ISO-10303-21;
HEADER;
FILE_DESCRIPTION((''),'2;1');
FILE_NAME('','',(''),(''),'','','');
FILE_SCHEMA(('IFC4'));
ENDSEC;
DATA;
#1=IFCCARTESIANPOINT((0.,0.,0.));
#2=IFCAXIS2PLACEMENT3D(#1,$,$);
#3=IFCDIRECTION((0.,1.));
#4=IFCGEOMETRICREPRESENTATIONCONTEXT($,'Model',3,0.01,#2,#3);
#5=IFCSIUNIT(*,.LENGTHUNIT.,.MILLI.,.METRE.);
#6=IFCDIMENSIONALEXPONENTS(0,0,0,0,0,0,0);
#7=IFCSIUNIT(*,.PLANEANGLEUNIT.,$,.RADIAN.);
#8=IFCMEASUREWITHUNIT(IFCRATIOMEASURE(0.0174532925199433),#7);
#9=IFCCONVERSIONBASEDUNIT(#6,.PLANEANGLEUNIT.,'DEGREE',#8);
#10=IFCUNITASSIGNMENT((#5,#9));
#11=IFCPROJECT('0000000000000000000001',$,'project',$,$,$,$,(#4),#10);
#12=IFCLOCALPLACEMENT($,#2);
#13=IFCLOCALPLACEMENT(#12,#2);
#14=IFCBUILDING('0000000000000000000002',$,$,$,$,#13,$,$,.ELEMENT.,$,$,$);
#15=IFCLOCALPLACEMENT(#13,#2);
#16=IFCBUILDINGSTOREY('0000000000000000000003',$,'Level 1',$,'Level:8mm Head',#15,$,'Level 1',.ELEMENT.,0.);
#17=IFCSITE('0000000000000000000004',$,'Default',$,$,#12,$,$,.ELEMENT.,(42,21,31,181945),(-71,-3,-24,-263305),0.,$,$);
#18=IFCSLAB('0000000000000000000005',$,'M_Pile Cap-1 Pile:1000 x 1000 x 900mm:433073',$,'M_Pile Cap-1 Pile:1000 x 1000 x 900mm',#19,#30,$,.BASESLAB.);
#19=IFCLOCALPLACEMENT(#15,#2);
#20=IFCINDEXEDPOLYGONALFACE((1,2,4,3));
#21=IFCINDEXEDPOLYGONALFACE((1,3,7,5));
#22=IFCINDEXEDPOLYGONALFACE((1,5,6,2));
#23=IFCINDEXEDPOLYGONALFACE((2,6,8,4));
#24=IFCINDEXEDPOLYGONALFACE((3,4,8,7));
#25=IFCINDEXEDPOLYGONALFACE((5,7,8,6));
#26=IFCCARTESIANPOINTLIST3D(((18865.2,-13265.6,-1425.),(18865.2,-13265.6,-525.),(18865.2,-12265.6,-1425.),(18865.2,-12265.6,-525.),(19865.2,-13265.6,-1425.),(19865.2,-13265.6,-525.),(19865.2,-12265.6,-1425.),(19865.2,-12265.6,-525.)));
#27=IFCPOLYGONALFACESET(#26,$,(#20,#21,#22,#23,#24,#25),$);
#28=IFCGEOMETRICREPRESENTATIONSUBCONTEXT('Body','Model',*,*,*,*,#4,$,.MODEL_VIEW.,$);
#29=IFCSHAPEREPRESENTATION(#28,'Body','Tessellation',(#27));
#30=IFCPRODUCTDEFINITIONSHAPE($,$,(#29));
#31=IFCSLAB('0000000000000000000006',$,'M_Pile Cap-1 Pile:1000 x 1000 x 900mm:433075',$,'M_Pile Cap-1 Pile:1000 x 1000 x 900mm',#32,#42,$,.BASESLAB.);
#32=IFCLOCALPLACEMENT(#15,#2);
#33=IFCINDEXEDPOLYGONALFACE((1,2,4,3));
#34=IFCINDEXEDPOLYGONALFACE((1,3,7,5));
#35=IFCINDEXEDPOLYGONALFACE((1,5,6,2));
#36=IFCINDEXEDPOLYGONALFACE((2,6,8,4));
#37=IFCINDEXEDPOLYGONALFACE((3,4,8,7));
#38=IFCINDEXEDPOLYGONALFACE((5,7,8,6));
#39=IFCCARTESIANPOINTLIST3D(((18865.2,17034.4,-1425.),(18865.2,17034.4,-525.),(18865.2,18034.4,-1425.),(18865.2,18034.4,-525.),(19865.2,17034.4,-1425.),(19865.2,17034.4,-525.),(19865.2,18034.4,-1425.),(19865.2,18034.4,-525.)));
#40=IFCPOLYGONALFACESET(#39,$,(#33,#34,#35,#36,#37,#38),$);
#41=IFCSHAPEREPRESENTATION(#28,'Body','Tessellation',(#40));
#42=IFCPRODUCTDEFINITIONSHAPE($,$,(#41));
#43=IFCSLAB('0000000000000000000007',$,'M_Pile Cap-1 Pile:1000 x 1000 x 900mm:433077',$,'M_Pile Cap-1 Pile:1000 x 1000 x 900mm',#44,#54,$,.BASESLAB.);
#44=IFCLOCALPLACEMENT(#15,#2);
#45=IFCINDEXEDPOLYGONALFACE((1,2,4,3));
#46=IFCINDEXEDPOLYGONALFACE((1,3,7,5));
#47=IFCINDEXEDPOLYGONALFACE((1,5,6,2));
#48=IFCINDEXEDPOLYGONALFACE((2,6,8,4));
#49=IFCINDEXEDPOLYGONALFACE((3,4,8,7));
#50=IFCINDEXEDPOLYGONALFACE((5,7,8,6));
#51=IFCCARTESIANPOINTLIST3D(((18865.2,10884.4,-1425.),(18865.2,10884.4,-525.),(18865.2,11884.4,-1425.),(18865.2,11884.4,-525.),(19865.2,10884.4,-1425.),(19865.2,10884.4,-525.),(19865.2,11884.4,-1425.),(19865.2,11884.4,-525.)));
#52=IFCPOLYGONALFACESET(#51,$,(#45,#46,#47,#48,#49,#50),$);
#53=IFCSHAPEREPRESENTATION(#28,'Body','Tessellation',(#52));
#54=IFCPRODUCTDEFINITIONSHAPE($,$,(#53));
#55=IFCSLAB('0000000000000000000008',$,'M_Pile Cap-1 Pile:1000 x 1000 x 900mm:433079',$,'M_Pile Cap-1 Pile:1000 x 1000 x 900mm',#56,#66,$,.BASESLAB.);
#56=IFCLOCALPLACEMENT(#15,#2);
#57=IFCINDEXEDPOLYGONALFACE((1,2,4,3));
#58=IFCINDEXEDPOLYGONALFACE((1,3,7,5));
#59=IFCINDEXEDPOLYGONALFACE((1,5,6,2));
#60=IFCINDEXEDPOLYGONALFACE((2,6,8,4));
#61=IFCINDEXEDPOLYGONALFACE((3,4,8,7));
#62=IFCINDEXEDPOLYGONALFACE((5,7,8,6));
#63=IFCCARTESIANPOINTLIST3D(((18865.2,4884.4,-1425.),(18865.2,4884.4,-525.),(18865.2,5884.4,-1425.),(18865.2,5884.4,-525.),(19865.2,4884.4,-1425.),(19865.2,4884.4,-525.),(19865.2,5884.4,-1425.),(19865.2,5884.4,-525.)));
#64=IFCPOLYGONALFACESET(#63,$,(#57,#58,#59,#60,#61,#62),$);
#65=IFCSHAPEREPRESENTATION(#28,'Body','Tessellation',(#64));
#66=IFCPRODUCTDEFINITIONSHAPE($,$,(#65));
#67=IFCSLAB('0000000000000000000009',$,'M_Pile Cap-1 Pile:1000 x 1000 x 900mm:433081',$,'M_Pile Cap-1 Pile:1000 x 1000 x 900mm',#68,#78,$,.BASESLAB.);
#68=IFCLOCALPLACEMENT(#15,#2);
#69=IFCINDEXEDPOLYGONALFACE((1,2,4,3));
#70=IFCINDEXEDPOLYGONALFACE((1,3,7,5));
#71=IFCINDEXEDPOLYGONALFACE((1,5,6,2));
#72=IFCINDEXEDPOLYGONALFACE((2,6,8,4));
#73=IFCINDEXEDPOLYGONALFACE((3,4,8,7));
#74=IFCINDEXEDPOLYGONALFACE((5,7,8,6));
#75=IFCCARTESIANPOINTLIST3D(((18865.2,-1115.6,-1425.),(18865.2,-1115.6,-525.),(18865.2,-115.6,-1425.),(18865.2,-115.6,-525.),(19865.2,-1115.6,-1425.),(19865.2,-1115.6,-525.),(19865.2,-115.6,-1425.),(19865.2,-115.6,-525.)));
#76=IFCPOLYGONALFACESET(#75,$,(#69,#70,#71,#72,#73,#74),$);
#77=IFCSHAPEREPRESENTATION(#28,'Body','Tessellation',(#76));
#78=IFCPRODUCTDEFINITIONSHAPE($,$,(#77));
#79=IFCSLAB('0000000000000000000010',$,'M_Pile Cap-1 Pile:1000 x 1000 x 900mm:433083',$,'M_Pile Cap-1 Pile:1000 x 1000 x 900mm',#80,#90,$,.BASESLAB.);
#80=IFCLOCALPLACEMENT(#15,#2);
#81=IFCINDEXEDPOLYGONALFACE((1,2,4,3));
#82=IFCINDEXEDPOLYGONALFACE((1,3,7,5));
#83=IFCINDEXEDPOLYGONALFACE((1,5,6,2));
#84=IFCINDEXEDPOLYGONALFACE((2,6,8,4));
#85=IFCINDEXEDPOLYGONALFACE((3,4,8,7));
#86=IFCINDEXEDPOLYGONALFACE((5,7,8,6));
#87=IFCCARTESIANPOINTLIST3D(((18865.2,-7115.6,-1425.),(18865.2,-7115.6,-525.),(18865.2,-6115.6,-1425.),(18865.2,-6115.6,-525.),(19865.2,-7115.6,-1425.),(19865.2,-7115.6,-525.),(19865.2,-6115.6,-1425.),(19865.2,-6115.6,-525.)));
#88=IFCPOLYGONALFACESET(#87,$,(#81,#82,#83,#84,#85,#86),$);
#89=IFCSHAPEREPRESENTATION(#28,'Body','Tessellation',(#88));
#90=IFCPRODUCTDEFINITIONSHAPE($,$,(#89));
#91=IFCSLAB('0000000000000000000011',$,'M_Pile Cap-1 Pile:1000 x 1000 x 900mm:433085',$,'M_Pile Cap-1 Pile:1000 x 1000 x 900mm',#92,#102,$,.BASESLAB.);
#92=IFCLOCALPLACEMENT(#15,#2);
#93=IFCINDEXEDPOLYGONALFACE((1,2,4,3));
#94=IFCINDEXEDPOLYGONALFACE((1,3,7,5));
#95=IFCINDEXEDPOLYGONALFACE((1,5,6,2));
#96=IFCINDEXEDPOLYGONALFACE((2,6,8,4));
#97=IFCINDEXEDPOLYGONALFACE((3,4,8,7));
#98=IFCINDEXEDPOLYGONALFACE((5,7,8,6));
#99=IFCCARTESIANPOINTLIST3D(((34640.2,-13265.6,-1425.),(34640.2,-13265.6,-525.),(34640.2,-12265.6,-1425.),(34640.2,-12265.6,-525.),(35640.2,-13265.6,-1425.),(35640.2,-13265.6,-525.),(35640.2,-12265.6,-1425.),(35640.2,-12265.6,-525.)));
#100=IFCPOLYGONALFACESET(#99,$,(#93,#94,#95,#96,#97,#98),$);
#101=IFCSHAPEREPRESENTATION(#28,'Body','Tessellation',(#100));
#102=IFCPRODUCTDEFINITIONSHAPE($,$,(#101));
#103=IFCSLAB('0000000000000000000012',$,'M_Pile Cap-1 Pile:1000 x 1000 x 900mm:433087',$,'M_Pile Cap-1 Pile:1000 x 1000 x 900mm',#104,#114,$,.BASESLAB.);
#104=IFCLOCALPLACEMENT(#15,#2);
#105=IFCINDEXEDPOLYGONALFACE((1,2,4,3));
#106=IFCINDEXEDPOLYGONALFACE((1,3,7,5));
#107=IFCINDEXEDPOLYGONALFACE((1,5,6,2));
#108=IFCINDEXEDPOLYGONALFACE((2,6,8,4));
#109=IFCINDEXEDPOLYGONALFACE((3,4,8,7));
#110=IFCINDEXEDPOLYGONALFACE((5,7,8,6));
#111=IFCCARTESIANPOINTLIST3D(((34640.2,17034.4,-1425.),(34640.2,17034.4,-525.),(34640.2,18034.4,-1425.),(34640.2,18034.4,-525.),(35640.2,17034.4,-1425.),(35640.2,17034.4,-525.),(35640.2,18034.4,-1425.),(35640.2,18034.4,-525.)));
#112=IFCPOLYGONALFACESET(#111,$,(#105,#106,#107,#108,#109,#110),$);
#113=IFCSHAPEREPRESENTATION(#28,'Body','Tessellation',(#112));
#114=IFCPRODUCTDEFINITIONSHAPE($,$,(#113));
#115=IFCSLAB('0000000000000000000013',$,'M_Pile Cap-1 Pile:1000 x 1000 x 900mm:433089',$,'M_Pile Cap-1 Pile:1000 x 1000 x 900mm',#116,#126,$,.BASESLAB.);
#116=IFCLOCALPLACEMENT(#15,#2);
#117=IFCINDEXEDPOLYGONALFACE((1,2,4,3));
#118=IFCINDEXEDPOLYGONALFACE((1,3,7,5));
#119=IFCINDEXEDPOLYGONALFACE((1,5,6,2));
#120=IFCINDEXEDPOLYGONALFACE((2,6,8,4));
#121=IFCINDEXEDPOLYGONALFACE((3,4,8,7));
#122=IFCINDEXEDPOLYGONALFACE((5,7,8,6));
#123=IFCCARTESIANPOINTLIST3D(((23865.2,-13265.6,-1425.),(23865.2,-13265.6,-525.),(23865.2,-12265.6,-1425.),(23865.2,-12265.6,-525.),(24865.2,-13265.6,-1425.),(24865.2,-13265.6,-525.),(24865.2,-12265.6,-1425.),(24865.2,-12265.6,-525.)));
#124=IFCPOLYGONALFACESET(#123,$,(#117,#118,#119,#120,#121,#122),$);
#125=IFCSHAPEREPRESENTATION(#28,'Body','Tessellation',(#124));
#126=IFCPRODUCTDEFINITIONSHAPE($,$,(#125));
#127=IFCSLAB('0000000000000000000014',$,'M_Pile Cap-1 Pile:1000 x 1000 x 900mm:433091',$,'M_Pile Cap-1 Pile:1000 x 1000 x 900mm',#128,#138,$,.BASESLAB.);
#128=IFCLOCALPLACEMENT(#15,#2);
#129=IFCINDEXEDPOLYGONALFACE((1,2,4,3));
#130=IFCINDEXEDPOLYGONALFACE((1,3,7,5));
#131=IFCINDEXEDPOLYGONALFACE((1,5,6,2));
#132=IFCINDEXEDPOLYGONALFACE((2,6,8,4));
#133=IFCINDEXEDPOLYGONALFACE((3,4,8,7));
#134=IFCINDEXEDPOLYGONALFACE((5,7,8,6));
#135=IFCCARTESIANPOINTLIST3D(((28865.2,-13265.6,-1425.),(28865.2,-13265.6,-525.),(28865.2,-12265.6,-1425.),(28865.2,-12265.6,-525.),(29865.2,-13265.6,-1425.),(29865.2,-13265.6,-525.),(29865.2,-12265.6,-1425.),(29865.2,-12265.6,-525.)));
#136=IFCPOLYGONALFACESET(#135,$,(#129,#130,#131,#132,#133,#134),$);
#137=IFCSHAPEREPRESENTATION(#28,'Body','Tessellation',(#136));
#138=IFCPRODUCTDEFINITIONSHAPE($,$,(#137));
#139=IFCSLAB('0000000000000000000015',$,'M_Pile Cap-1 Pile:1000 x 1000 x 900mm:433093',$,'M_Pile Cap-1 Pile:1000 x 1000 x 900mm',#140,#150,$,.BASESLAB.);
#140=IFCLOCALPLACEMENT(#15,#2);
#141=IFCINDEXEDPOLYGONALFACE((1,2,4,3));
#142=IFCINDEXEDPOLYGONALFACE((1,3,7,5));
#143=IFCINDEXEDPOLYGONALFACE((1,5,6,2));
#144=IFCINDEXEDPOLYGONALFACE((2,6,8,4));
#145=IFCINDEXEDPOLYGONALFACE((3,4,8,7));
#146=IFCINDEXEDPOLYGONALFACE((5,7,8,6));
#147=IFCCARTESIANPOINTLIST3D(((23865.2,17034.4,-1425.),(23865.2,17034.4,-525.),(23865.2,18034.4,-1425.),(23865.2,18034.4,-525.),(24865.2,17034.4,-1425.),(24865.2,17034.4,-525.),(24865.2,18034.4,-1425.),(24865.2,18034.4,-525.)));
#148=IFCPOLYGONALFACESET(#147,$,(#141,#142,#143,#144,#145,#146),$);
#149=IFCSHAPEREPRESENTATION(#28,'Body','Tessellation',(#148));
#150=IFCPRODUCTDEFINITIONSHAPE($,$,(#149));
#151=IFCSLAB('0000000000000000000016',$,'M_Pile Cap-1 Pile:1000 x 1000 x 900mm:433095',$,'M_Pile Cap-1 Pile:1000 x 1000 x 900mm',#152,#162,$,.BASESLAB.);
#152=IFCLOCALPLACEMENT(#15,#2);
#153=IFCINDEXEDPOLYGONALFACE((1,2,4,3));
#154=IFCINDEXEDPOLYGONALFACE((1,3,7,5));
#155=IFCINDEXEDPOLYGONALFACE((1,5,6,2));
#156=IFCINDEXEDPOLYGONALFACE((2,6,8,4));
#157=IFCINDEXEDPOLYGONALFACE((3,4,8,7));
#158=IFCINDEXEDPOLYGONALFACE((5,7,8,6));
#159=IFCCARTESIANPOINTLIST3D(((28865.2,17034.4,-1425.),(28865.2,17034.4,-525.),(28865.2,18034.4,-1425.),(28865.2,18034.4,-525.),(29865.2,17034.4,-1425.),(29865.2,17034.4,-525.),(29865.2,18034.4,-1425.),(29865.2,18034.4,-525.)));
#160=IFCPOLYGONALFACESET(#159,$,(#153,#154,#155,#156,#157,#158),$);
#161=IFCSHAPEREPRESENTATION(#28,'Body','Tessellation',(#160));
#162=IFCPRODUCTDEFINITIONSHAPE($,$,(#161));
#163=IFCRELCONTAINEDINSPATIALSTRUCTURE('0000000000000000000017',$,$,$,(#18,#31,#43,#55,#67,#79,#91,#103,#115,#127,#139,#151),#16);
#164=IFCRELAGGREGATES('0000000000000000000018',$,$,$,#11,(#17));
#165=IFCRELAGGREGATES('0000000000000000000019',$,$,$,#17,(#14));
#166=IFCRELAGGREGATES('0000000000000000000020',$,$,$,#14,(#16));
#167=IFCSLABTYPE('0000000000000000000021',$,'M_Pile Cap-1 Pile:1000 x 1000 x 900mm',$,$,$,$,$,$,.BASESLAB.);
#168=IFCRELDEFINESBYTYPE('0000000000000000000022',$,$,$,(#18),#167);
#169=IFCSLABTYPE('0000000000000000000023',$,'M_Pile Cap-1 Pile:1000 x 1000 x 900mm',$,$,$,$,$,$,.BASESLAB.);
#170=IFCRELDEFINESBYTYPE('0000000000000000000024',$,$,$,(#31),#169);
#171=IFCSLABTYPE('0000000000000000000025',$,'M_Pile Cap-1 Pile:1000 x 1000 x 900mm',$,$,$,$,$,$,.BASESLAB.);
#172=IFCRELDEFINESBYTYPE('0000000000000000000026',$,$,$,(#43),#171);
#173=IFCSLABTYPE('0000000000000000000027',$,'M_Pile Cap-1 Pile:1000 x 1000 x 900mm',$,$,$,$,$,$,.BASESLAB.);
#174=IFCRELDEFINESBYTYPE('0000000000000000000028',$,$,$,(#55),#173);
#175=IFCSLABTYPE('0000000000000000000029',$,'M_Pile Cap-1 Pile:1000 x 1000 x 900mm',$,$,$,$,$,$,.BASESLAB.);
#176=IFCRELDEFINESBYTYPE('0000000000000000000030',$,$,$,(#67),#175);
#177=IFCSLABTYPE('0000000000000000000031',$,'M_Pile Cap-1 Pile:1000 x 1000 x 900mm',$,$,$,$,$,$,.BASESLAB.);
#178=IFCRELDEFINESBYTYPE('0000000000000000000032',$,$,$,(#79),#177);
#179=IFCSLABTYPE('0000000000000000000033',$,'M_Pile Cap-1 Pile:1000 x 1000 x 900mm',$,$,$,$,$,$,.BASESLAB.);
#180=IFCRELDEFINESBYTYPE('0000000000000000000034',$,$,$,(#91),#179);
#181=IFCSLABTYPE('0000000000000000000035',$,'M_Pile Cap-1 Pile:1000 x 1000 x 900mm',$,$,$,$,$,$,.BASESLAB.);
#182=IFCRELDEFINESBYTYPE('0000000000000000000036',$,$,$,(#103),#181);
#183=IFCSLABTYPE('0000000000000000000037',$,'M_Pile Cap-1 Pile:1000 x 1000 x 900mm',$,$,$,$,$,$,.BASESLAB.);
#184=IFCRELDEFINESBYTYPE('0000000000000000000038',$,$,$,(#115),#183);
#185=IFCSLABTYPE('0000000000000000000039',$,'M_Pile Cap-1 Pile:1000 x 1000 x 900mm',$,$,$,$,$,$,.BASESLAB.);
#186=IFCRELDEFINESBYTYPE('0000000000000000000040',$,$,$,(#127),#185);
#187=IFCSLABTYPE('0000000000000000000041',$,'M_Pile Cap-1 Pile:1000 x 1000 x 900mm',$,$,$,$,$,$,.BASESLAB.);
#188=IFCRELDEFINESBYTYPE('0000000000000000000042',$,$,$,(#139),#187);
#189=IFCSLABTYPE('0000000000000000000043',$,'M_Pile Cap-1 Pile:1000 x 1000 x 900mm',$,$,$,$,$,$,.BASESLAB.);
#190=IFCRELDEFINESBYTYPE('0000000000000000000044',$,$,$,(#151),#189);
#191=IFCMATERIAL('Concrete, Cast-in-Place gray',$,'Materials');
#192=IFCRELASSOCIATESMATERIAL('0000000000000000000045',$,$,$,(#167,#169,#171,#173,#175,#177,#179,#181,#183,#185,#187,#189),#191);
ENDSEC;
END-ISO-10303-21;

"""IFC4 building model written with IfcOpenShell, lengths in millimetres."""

from ifc_helpers import new_model, entity, si_unit, converted_unit, direction, frame, origin, place, context, subcontext, project, spatial, indexed_curve, outline, extrude, material, type_object, element, save


model = new_model("IFC4")

# Units and contexts
model_context = context("Model", 3, precision=0.01, world=origin(), true_north=direction((0.0, 1.0)))
body_context = subcontext(model_context, "Body", "Model", "MODEL_VIEW")
ifc_project = project(units=[si_unit("LENGTHUNIT", "METRE", prefix="MILLI"), converted_unit("PLANEANGLEUNIT", "DEGREE", entity("IfcRatioMeasure", 0.0174532925199433), si_unit("PLANEANGLEUNIT", "RADIAN"), dimensions=[0, 0, 0, 0, 0, 0, 0])], contexts=[model_context])

# Site, building, storey
site_placement = place(None, origin())
site = spatial("IfcSite", under=ifc_project, at=site_placement, Name="Default", CompositionType="ELEMENT", RefLatitude=(42, 21, 31, 181945), RefLongitude=(-71, -3, -24, -263305), RefElevation=0.0)
building_placement = place(site_placement, origin())
building = spatial("IfcBuilding", under=site, at=building_placement, CompositionType="ELEMENT")
storey_placement = place(building_placement, origin())
storey = spatial("IfcBuildingStorey", under=building, at=storey_placement, Name="Level 1", ObjectType="Level:8mm Head", LongName="Level 1", CompositionType="ELEMENT", Elevation=0.0)

# Slabs
ifc_material_1 = material(Name="Concrete, Cast-in-Place gray", Category="Materials")
slab_type_1 = type_object("IfcSlabType", Name="M_Pile Cap-1 Pile:1000 x 1000 x 900mm", PredefinedType="BASESLAB", material=ifc_material_1)
slab_1_placement = place(building_placement, origin())
element("IfcSlab", 1, at=slab_1_placement, inside=storey, type_object=slab_type_1, Name="M_Pile Cap-1 Pile:1000 x 1000 x 900mm:433073", ObjectType="M_Pile Cap-1 Pile:1000 x 1000 x 900mm", PredefinedType="BASESLAB", context=body_context, shape_type="SweptSolid", body=[
    extrude(outline(indexed_curve([(-500.0, -500.0), (500.0, -500.0), (500.0, 500.0), (-500.0, 500.0), (-500.0, -500.0)], self_intersect=False)), frame((19365.2, -12765.6, -1425.0), z_axis=(0.0, 0.0, 1.0), x_axis=(-1.0, 0.0, 0.0)), (0.0, 0.0, 1.0), 900.0),
])
slab_type_2 = type_object("IfcSlabType", Name="M_Pile Cap-1 Pile:1000 x 1000 x 900mm", PredefinedType="BASESLAB", material=ifc_material_1)
slab_2_placement = place(building_placement, origin())
element("IfcSlab", 2, at=slab_2_placement, inside=storey, type_object=slab_type_2, Name="M_Pile Cap-1 Pile:1000 x 1000 x 900mm:433075", ObjectType="M_Pile Cap-1 Pile:1000 x 1000 x 900mm", PredefinedType="BASESLAB", context=body_context, shape_type="SweptSolid", body=[
    extrude(outline(indexed_curve([(-500.0, -500.0), (500.0, -500.0), (500.0, 500.0), (-500.0, 500.0), (-500.0, -500.0)], self_intersect=False)), frame((19365.2, 17534.4, -1425.0), z_axis=(0.0, 0.0, 1.0), x_axis=(-1.0, 0.0, 0.0)), (0.0, 0.0, 1.0), 900.0),
])
slab_type_3 = type_object("IfcSlabType", Name="M_Pile Cap-1 Pile:1000 x 1000 x 900mm", PredefinedType="BASESLAB", material=ifc_material_1)
slab_3_placement = place(building_placement, origin())
element("IfcSlab", 3, at=slab_3_placement, inside=storey, type_object=slab_type_3, Name="M_Pile Cap-1 Pile:1000 x 1000 x 900mm:433077", ObjectType="M_Pile Cap-1 Pile:1000 x 1000 x 900mm", PredefinedType="BASESLAB", context=body_context, shape_type="SweptSolid", body=[
    extrude(outline(indexed_curve([(-500.0, -500.0), (500.0, -500.0), (500.0, 500.0), (-500.0, 500.0), (-500.0, -500.0)], self_intersect=False)), frame((19365.2, 11384.4, -1425.0), z_axis=(0.0, 0.0, 1.0), x_axis=(-1.0, 0.0, 0.0)), (0.0, 0.0, 1.0), 900.0),
])
slab_type_4 = type_object("IfcSlabType", Name="M_Pile Cap-1 Pile:1000 x 1000 x 900mm", PredefinedType="BASESLAB", material=ifc_material_1)
slab_4_placement = place(building_placement, origin())
element("IfcSlab", 4, at=slab_4_placement, inside=storey, type_object=slab_type_4, Name="M_Pile Cap-1 Pile:1000 x 1000 x 900mm:433079", ObjectType="M_Pile Cap-1 Pile:1000 x 1000 x 900mm", PredefinedType="BASESLAB", context=body_context, shape_type="SweptSolid", body=[
    extrude(outline(indexed_curve([(-500.0, -500.0), (500.0, -500.0), (500.0, 500.0), (-500.0, 500.0), (-500.0, -500.0)], self_intersect=False)), frame((19365.2, 5384.4, -1425.0), z_axis=(0.0, 0.0, 1.0), x_axis=(-1.0, 0.0, 0.0)), (0.0, 0.0, 1.0), 900.0),
])
slab_type_5 = type_object("IfcSlabType", Name="M_Pile Cap-1 Pile:1000 x 1000 x 900mm", PredefinedType="BASESLAB", material=ifc_material_1)
slab_5_placement = place(building_placement, origin())
element("IfcSlab", 5, at=slab_5_placement, inside=storey, type_object=slab_type_5, Name="M_Pile Cap-1 Pile:1000 x 1000 x 900mm:433081", ObjectType="M_Pile Cap-1 Pile:1000 x 1000 x 900mm", PredefinedType="BASESLAB", context=body_context, shape_type="SweptSolid", body=[
    extrude(outline(indexed_curve([(-500.0, -500.0), (500.0, -500.0), (500.0, 500.0), (-500.0, 500.0), (-500.0, -500.0)], self_intersect=False)), frame((19365.2, -615.6, -1425.0), z_axis=(0.0, 0.0, 1.0), x_axis=(-1.0, 0.0, 0.0)), (0.0, 0.0, 1.0), 900.0),
])
slab_type_6 = type_object("IfcSlabType", Name="M_Pile Cap-1 Pile:1000 x 1000 x 900mm", PredefinedType="BASESLAB", material=ifc_material_1)
slab_6_placement = place(building_placement, origin())
element("IfcSlab", 6, at=slab_6_placement, inside=storey, type_object=slab_type_6, Name="M_Pile Cap-1 Pile:1000 x 1000 x 900mm:433083", ObjectType="M_Pile Cap-1 Pile:1000 x 1000 x 900mm", PredefinedType="BASESLAB", context=body_context, shape_type="SweptSolid", body=[
    extrude(outline(indexed_curve([(-500.0, -500.0), (500.0, -500.0), (500.0, 500.0), (-500.0, 500.0), (-500.0, -500.0)], self_intersect=False)), frame((19365.2, -6615.6, -1425.0), z_axis=(0.0, 0.0, 1.0), x_axis=(-1.0, 0.0, 0.0)), (0.0, 0.0, 1.0), 900.0),
])
slab_type_7 = type_object("IfcSlabType", Name="M_Pile Cap-1 Pile:1000 x 1000 x 900mm", PredefinedType="BASESLAB", material=ifc_material_1)
slab_7_placement = place(building_placement, origin())
element("IfcSlab", 7, at=slab_7_placement, inside=storey, type_object=slab_type_7, Name="M_Pile Cap-1 Pile:1000 x 1000 x 900mm:433085", ObjectType="M_Pile Cap-1 Pile:1000 x 1000 x 900mm", PredefinedType="BASESLAB", context=body_context, shape_type="SweptSolid", body=[
    extrude(outline(indexed_curve([(-500.0, -500.0), (500.0, -500.0), (500.0, 500.0), (-500.0, 500.0), (-500.0, -500.0)], self_intersect=False)), frame((35140.2, -12765.6, -1425.0), z_axis=(0.0, 0.0, 1.0), x_axis=(-1.0, 0.0, 0.0)), (0.0, 0.0, 1.0), 900.0),
])
slab_type_8 = type_object("IfcSlabType", Name="M_Pile Cap-1 Pile:1000 x 1000 x 900mm", PredefinedType="BASESLAB", material=ifc_material_1)
slab_8_placement = place(building_placement, origin())
element("IfcSlab", 8, at=slab_8_placement, inside=storey, type_object=slab_type_8, Name="M_Pile Cap-1 Pile:1000 x 1000 x 900mm:433087", ObjectType="M_Pile Cap-1 Pile:1000 x 1000 x 900mm", PredefinedType="BASESLAB", context=body_context, shape_type="SweptSolid", body=[
    extrude(outline(indexed_curve([(-500.0, -500.0), (500.0, -500.0), (500.0, 500.0), (-500.0, 500.0), (-500.0, -500.0)], self_intersect=False)), frame((35140.2, 17534.4, -1425.0), z_axis=(0.0, 0.0, 1.0), x_axis=(-1.0, 0.0, 0.0)), (0.0, 0.0, 1.0), 900.0),
])
slab_type_9 = type_object("IfcSlabType", Name="M_Pile Cap-1 Pile:1000 x 1000 x 900mm", PredefinedType="BASESLAB", material=ifc_material_1)
slab_9_placement = place(building_placement, origin())
element("IfcSlab", 9, at=slab_9_placement, inside=storey, type_object=slab_type_9, Name="M_Pile Cap-1 Pile:1000 x 1000 x 900mm:433089", ObjectType="M_Pile Cap-1 Pile:1000 x 1000 x 900mm", PredefinedType="BASESLAB", context=body_context, shape_type="SweptSolid", body=[
    extrude(outline(indexed_curve([(-500.0, -500.0), (500.0, -500.0), (500.0, 500.0), (-500.0, 500.0), (-500.0, -500.0)], self_intersect=False)), frame((24365.2, -12765.6, -1425.0), z_axis=(0.0, 0.0, 1.0), x_axis=(-1.0, 0.0, 0.0)), (0.0, 0.0, 1.0), 900.0),
])
slab_type_10 = type_object("IfcSlabType", Name="M_Pile Cap-1 Pile:1000 x 1000 x 900mm", PredefinedType="BASESLAB", material=ifc_material_1)
slab_10_placement = place(building_placement, origin())
element("IfcSlab", 10, at=slab_10_placement, inside=storey, type_object=slab_type_10, Name="M_Pile Cap-1 Pile:1000 x 1000 x 900mm:433091", ObjectType="M_Pile Cap-1 Pile:1000 x 1000 x 900mm", PredefinedType="BASESLAB", context=body_context, shape_type="SweptSolid", body=[
    extrude(outline(indexed_curve([(-500.0, -500.0), (500.0, -500.0), (500.0, 500.0), (-500.0, 500.0), (-500.0, -500.0)], self_intersect=False)), frame((29365.2, -12765.6, -1425.0), z_axis=(0.0, 0.0, 1.0), x_axis=(-1.0, 0.0, 0.0)), (0.0, 0.0, 1.0), 900.0),
])
slab_type_11 = type_object("IfcSlabType", Name="M_Pile Cap-1 Pile:1000 x 1000 x 900mm", PredefinedType="BASESLAB", material=ifc_material_1)
slab_11_placement = place(building_placement, origin())
element("IfcSlab", 11, at=slab_11_placement, inside=storey, type_object=slab_type_11, Name="M_Pile Cap-1 Pile:1000 x 1000 x 900mm:433093", ObjectType="M_Pile Cap-1 Pile:1000 x 1000 x 900mm", PredefinedType="BASESLAB", context=body_context, shape_type="SweptSolid", body=[
    extrude(outline(indexed_curve([(-500.0, -500.0), (500.0, -500.0), (500.0, 500.0), (-500.0, 500.0), (-500.0, -500.0)], self_intersect=False)), frame((24365.2, 17534.4, -1425.0), z_axis=(0.0, 0.0, 1.0), x_axis=(-1.0, 0.0, 0.0)), (0.0, 0.0, 1.0), 900.0),
])
slab_type_12 = type_object("IfcSlabType", Name="M_Pile Cap-1 Pile:1000 x 1000 x 900mm", PredefinedType="BASESLAB", material=ifc_material_1)
slab_12_placement = place(building_placement, origin())
element("IfcSlab", 12, at=slab_12_placement, inside=storey, type_object=slab_type_12, Name="M_Pile Cap-1 Pile:1000 x 1000 x 900mm:433095", ObjectType="M_Pile Cap-1 Pile:1000 x 1000 x 900mm", PredefinedType="BASESLAB", context=body_context, shape_type="SweptSolid", body=[
    extrude(outline(indexed_curve([(-500.0, -500.0), (500.0, -500.0), (500.0, 500.0), (-500.0, 500.0), (-500.0, -500.0)], self_intersect=False)), frame((29365.2, 17534.4, -1425.0), z_axis=(0.0, 0.0, 1.0), x_axis=(-1.0, 0.0, 0.0)), (0.0, 0.0, 1.0), 900.0),
])

save(model, "model.ifc")
